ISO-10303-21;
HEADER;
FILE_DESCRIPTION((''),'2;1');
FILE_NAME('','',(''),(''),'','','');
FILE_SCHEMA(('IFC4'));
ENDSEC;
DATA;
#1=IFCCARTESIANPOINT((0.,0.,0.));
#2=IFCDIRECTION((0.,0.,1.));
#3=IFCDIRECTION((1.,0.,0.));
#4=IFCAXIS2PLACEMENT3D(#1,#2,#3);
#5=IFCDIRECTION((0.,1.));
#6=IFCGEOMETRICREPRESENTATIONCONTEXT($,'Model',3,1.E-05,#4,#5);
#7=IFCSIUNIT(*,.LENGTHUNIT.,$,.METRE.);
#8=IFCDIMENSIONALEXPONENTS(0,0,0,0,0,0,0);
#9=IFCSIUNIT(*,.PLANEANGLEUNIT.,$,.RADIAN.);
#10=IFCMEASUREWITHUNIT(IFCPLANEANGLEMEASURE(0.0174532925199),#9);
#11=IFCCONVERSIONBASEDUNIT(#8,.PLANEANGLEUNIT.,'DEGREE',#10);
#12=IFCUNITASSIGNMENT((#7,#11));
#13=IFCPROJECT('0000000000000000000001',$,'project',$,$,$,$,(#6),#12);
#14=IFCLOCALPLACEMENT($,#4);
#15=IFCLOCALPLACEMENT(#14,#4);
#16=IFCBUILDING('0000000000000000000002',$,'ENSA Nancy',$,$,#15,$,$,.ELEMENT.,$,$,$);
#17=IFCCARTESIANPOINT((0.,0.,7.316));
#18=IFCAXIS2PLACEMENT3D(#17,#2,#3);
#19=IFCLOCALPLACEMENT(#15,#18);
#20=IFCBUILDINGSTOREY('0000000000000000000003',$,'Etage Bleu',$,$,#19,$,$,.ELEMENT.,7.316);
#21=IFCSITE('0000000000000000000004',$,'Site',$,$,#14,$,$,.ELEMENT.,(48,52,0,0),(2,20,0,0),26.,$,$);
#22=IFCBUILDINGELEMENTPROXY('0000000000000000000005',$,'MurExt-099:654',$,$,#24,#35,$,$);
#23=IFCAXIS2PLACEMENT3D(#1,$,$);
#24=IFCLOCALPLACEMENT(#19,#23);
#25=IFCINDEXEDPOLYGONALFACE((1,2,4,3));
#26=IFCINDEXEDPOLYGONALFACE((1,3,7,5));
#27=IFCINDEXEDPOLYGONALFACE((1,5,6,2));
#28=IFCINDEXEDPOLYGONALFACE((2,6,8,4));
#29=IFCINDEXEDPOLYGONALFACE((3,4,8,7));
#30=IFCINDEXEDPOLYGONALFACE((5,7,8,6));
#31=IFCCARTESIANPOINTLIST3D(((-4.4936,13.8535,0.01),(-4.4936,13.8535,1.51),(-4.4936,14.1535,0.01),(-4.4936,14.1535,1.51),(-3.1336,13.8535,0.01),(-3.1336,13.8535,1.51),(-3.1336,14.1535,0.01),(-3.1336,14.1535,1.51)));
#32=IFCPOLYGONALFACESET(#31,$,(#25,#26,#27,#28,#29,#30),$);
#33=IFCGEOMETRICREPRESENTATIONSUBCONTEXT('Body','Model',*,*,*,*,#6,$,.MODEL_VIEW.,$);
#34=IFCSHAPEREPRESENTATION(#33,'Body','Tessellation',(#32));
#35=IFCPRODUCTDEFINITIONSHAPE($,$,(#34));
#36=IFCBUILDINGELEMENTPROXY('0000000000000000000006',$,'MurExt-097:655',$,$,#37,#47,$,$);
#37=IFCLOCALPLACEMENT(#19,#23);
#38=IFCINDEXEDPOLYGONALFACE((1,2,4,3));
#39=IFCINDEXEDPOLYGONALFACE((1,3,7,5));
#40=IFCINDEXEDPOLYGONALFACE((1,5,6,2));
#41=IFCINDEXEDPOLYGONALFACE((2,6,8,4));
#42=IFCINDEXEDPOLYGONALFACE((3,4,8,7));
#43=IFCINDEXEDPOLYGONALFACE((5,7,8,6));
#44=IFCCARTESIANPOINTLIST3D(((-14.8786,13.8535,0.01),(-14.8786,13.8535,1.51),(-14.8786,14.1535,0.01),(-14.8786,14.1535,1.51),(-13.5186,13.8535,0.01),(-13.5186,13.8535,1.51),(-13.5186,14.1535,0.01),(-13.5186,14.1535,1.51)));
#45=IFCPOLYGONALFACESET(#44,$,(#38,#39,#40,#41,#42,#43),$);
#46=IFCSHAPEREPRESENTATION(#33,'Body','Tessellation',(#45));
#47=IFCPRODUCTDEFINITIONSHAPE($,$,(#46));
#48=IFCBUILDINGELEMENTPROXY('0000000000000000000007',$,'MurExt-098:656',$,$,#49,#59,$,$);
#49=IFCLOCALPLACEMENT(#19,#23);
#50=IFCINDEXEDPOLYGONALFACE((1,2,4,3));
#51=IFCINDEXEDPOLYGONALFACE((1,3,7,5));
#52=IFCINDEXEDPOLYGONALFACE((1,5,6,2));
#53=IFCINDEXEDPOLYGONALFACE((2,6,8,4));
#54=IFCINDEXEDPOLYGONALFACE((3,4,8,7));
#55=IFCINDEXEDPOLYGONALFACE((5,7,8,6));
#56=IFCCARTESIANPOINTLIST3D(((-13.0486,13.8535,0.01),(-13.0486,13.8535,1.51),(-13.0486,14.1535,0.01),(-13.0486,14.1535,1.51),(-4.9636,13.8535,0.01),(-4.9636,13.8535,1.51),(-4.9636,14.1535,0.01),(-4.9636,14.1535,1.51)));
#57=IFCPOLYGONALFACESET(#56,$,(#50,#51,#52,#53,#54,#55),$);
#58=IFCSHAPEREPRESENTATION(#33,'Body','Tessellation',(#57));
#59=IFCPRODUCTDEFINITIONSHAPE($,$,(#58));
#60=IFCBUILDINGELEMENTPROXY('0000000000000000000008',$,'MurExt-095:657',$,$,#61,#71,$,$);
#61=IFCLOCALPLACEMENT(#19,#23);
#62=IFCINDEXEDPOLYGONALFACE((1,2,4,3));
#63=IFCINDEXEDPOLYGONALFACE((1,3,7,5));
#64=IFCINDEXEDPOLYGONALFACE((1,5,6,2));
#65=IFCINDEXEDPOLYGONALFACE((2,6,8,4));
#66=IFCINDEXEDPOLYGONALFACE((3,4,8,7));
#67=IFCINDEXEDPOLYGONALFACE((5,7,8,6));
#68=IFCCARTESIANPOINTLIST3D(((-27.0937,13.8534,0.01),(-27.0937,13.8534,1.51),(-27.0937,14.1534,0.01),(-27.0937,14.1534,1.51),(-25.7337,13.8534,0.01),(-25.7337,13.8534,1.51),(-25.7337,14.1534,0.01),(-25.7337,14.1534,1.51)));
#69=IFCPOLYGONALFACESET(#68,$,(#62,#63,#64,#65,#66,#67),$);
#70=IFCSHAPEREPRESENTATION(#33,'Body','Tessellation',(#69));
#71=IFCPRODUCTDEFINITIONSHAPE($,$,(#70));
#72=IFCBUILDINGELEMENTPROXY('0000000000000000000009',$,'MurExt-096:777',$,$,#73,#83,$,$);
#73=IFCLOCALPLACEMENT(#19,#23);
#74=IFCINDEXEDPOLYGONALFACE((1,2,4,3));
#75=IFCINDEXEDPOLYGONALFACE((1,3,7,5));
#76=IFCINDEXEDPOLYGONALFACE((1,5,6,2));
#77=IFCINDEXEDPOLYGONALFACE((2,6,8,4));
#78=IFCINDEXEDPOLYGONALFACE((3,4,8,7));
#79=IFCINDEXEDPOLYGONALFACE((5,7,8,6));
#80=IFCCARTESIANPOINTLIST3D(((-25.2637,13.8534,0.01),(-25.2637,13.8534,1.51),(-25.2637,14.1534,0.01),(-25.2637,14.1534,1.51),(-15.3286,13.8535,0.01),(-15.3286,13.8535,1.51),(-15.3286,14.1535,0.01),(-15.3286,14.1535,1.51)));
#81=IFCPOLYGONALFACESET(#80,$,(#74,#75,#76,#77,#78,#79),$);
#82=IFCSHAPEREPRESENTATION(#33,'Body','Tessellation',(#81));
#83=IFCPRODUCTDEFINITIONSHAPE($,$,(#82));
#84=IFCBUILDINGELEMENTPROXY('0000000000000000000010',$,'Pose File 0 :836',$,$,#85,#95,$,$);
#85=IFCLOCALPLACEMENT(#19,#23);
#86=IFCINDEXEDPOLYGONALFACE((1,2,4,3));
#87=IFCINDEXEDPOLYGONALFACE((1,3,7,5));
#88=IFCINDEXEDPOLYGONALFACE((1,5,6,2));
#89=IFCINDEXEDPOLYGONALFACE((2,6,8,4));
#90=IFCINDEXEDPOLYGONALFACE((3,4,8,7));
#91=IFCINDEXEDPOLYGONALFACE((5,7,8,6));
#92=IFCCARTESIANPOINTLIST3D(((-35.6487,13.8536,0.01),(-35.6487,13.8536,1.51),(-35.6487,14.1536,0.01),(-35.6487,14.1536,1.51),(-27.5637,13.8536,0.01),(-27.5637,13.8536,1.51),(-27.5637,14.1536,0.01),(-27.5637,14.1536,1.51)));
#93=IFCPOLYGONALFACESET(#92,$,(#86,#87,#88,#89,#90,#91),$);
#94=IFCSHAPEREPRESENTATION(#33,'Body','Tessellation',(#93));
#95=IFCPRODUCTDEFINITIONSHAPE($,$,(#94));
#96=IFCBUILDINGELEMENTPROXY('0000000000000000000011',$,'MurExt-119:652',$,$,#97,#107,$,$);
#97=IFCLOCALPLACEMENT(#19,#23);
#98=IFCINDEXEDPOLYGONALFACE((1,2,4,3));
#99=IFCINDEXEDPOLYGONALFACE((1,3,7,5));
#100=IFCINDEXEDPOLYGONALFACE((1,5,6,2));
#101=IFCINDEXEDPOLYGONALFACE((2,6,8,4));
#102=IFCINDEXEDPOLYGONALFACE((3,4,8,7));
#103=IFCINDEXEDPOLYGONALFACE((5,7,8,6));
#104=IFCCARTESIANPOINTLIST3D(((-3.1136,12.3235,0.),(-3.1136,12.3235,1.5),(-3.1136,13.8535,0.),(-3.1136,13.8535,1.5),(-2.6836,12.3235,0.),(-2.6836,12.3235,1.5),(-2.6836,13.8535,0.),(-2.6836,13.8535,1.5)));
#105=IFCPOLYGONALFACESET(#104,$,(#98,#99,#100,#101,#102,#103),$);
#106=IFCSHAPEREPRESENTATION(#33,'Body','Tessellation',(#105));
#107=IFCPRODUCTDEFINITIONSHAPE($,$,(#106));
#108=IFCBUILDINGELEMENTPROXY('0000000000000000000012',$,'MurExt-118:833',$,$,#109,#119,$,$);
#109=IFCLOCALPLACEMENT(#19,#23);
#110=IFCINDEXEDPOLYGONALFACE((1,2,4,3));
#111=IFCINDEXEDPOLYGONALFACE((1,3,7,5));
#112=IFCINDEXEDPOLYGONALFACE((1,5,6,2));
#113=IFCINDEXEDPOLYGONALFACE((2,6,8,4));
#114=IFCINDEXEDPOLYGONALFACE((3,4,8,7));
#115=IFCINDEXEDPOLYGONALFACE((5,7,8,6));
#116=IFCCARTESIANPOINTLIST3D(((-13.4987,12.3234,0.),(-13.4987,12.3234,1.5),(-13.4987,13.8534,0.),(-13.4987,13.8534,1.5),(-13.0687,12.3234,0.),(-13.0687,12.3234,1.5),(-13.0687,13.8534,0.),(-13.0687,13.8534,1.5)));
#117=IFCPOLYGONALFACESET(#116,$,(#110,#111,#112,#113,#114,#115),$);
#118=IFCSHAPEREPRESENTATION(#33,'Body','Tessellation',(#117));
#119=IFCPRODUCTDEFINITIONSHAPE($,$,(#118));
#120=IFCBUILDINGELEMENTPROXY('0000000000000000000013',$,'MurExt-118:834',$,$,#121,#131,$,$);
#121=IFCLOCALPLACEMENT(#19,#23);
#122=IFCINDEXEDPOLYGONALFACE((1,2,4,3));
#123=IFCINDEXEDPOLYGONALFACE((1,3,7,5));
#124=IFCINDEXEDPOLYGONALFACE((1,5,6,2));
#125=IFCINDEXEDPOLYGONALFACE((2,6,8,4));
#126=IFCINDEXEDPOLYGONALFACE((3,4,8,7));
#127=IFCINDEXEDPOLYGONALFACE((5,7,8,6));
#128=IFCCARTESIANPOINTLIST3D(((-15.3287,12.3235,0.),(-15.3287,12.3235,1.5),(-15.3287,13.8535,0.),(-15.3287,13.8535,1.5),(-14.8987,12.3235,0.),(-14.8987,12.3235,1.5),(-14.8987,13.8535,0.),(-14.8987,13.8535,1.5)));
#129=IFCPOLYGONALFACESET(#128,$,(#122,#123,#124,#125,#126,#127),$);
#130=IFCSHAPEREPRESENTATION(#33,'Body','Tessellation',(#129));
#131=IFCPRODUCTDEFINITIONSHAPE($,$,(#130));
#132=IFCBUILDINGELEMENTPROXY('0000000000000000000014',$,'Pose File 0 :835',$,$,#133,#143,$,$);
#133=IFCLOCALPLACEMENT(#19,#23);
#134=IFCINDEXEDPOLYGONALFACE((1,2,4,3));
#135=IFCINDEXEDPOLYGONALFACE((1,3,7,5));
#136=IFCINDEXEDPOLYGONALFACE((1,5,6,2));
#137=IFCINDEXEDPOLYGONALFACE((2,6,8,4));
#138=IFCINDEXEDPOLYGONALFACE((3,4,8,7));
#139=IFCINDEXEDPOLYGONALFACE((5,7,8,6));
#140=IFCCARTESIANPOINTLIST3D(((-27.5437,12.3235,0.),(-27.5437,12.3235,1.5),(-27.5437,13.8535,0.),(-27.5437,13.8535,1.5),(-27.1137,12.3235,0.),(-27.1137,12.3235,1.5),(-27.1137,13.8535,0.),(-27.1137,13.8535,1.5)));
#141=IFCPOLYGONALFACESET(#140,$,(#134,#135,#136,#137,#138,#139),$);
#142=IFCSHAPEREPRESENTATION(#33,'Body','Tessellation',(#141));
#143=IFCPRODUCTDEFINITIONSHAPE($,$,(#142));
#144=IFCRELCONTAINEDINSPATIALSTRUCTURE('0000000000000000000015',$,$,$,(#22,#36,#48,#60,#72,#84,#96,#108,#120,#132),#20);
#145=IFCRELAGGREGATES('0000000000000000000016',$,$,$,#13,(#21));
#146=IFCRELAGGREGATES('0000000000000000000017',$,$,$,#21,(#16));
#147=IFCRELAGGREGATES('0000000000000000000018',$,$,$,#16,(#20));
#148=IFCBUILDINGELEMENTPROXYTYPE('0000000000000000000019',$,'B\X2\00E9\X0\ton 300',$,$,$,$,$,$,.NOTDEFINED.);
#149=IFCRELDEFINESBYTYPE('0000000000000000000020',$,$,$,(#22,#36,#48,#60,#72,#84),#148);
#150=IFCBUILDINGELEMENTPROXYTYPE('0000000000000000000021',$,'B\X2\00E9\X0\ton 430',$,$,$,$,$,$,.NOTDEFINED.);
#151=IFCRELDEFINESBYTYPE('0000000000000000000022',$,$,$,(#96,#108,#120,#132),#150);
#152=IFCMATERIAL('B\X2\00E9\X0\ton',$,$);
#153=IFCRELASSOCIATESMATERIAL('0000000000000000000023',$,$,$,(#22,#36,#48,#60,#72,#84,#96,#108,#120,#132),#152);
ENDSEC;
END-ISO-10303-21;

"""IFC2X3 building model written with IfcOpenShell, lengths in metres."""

from ifc_helpers import new_model, entity, si_unit, converted_unit, direction, frame, origin_with_axes, place, context, subcontext, project, spatial, polyline, outline, extrude, material, type_object, element, save


model = new_model("IFC2X3")

# Units and contexts
model_context = context("Model", 3, precision=1e-05, world=origin_with_axes(), true_north=direction((0.0, 1.0)))
body_context = subcontext(model_context, "Body", "Model", "MODEL_VIEW")
ifc_project = project(units=[si_unit("LENGTHUNIT", "METRE"), converted_unit("PLANEANGLEUNIT", "DEGREE", entity("IfcPlaneAngleMeasure", 0.0174532925199), si_unit("PLANEANGLEUNIT", "RADIAN"), dimensions=[0, 0, 0, 0, 0, 0, 0])], contexts=[model_context])

# Site, building, storey
site_placement = place(None, origin_with_axes())
site = spatial("IfcSite", under=ifc_project, at=site_placement, Name="Site", CompositionType="ELEMENT", RefLatitude=(48, 52, 0, 0), RefLongitude=(2, 20, 0, 0), RefElevation=26.0)
building_placement = place(site_placement, origin_with_axes())
building = spatial("IfcBuilding", under=site, at=building_placement, Name="ENSA Nancy", CompositionType="ELEMENT")
storey_placement = place(building_placement, frame((0.0, 0.0, 7.316), z_axis=(0.0, 0.0, 1.0), x_axis=(1.0, 0.0, 0.0)))
storey = spatial("IfcBuildingStorey", under=building, at=storey_placement, Name="Etage Bleu", CompositionType="ELEMENT", Elevation=7.316)

# Building element proxies
ifc_material = material(Name="Béton")
building_element_proxy_type_1 = type_object("IfcBuildingElementProxyType", Name="Béton 300", PredefinedType="NOTDEFINED")
proxy_1_placement = place(storey_placement, frame((-4.4936, 13.8535, 0.01), z_axis=(0.0, 0.0, 1.0), x_axis=(1.0, 0.0, 0.0)))
element("IfcBuildingElementProxy", 1, at=proxy_1_placement, inside=storey, type_object=building_element_proxy_type_1, material=ifc_material, Name="MurExt-099:654", context=body_context, shape_type="SweptSolid", body=[
    extrude(outline(polyline([(0.0, 0.0), (1.36, 0.0), (1.36, 0.3), (0.0, 0.3), (0.0, 0.0)])), origin_with_axes(), (0.0, 0.0, 1.0), 1.5),
])
proxy_2_placement = place(storey_placement, frame((-14.8786, 13.8535, 0.01), z_axis=(0.0, 0.0, 1.0), x_axis=(1.0, 0.0, 0.0)))
element("IfcBuildingElementProxy", 2, at=proxy_2_placement, inside=storey, type_object=building_element_proxy_type_1, material=ifc_material, Name="MurExt-097:655", context=body_context, shape_type="SweptSolid", body=[
    extrude(outline(polyline([(0.0, 0.0), (1.36, 0.0), (1.36, 0.3), (0.0, 0.3), (0.0, 0.0)])), origin_with_axes(), (0.0, 0.0, 1.0), 1.5),
])
proxy_3_placement = place(storey_placement, frame((-13.0486, 13.8535, 0.01), z_axis=(0.0, 0.0, 1.0), x_axis=(1.0, 0.0, 0.0)))
element("IfcBuildingElementProxy", 3, at=proxy_3_placement, inside=storey, type_object=building_element_proxy_type_1, material=ifc_material, Name="MurExt-098:656", context=body_context, shape_type="SweptSolid", body=[
    extrude(outline(polyline([(0.0, 0.0), (8.085, 0.0), (8.085, 0.3), (0.0, 0.3), (0.0, 0.0)])), origin_with_axes(), (0.0, 0.0, 1.0), 1.5),
])
proxy_4_placement = place(storey_placement, frame((-27.0937, 13.8534, 0.01), z_axis=(0.0, 0.0, 1.0), x_axis=(1.0, 0.0, 0.0)))
element("IfcBuildingElementProxy", 4, at=proxy_4_placement, inside=storey, type_object=building_element_proxy_type_1, material=ifc_material, Name="MurExt-095:657", context=body_context, shape_type="SweptSolid", body=[
    extrude(outline(polyline([(0.0, 0.0), (1.36, 0.0), (1.36, 0.3), (0.0, 0.3), (0.0, 0.0)])), origin_with_axes(), (0.0, 0.0, 1.0), 1.5),
])
proxy_5_placement = place(storey_placement, frame((-25.2637, 13.8534, 0.01), z_axis=(0.0, 0.0, 1.0), x_axis=(1.0, 0.000009, 0.0)))
element("IfcBuildingElementProxy", 5, at=proxy_5_placement, inside=storey, type_object=building_element_proxy_type_1, material=ifc_material, Name="MurExt-096:777", context=body_context, shape_type="SweptSolid", body=[
    extrude(outline(polyline([(0.0, 0.0), (9.9351, 0.0), (9.9351, 0.3), (0.0, 0.3), (0.0, 0.0)])), origin_with_axes(), (0.0, 0.0, 1.0), 1.5),
])
proxy_6_placement = place(storey_placement, frame((-27.5637, 13.8536, 0.01), z_axis=(0.0, 0.0, 1.0), x_axis=(-1.0, 0.0, 0.0)))
element("IfcBuildingElementProxy", 6, at=proxy_6_placement, inside=storey, type_object=building_element_proxy_type_1, material=ifc_material, Name="Pose File 0 :836", context=body_context, shape_type="SweptSolid", body=[
    extrude(outline(polyline([(0.0, -0.3), (8.085, -0.3), (8.085, 0.0), (0.0, 0.0), (0.0, -0.3)])), origin_with_axes(), (0.0, 0.0, 1.0), 1.5),
])
building_element_proxy_type_2 = type_object("IfcBuildingElementProxyType", Name="Béton 430", PredefinedType="NOTDEFINED")
proxy_7_placement = place(storey_placement, frame((-3.1136, 13.8535, 0.0), z_axis=(0.0, 0.0, 1.0), x_axis=(0.0, -1.0, 0.0)))
element("IfcBuildingElementProxy", 7, at=proxy_7_placement, inside=storey, type_object=building_element_proxy_type_2, material=ifc_material, Name="MurExt-119:652", context=body_context, shape_type="SweptSolid", body=[
    extrude(outline(polyline([(0.0, 0.0), (1.53, 0.0), (1.53, 0.43), (0.0, 0.43), (0.0, 0.0)])), origin_with_axes(), (0.0, 0.0, 1.0), 1.5),
])
for number, where, z_axis, x_axis, name in (
    (8, (-13.4987, 13.8534, 0.0), (0.0, 0.0, 1.0), (0.0, -1.0, 0.0), "MurExt-118:833"),
    (9, (-15.3287, 13.8535, 0.0), (0.0, 0.0, 1.0), (0.0, -1.0, 0.0), "MurExt-118:834"),
):
    element("IfcBuildingElementProxy", number, at=place(storey_placement, frame(where, z_axis=z_axis, x_axis=x_axis)), inside=storey, type_object=building_element_proxy_type_2, material=ifc_material, Name=name, context=body_context, shape_type="SweptSolid", body=[
        extrude(outline(polyline([(0.0, 0.0), (1.53, 0.0), (1.53, 0.43), (0.0, 0.43), (0.0, 0.0)])), origin_with_axes(), (0.0, 0.0, 1.0), 1.5),
    ])
proxy_8_placement = place(storey_placement, frame((-27.1137, 13.8535, 0.0), z_axis=(0.0, 0.0, 1.0), x_axis=(0.0, -1.0, 0.0)))
element("IfcBuildingElementProxy", 10, at=proxy_8_placement, inside=storey, type_object=building_element_proxy_type_2, material=ifc_material, Name="Pose File 0 :835", context=body_context, shape_type="SweptSolid", body=[
    extrude(outline(polyline([(0.0, -0.43), (1.53, -0.43), (1.53, 0.0), (0.0, 0.0), (0.0, -0.43)])), origin_with_axes(), (0.0, 0.0, 1.0), 1.5),
])

save(model, "model.ifc")
